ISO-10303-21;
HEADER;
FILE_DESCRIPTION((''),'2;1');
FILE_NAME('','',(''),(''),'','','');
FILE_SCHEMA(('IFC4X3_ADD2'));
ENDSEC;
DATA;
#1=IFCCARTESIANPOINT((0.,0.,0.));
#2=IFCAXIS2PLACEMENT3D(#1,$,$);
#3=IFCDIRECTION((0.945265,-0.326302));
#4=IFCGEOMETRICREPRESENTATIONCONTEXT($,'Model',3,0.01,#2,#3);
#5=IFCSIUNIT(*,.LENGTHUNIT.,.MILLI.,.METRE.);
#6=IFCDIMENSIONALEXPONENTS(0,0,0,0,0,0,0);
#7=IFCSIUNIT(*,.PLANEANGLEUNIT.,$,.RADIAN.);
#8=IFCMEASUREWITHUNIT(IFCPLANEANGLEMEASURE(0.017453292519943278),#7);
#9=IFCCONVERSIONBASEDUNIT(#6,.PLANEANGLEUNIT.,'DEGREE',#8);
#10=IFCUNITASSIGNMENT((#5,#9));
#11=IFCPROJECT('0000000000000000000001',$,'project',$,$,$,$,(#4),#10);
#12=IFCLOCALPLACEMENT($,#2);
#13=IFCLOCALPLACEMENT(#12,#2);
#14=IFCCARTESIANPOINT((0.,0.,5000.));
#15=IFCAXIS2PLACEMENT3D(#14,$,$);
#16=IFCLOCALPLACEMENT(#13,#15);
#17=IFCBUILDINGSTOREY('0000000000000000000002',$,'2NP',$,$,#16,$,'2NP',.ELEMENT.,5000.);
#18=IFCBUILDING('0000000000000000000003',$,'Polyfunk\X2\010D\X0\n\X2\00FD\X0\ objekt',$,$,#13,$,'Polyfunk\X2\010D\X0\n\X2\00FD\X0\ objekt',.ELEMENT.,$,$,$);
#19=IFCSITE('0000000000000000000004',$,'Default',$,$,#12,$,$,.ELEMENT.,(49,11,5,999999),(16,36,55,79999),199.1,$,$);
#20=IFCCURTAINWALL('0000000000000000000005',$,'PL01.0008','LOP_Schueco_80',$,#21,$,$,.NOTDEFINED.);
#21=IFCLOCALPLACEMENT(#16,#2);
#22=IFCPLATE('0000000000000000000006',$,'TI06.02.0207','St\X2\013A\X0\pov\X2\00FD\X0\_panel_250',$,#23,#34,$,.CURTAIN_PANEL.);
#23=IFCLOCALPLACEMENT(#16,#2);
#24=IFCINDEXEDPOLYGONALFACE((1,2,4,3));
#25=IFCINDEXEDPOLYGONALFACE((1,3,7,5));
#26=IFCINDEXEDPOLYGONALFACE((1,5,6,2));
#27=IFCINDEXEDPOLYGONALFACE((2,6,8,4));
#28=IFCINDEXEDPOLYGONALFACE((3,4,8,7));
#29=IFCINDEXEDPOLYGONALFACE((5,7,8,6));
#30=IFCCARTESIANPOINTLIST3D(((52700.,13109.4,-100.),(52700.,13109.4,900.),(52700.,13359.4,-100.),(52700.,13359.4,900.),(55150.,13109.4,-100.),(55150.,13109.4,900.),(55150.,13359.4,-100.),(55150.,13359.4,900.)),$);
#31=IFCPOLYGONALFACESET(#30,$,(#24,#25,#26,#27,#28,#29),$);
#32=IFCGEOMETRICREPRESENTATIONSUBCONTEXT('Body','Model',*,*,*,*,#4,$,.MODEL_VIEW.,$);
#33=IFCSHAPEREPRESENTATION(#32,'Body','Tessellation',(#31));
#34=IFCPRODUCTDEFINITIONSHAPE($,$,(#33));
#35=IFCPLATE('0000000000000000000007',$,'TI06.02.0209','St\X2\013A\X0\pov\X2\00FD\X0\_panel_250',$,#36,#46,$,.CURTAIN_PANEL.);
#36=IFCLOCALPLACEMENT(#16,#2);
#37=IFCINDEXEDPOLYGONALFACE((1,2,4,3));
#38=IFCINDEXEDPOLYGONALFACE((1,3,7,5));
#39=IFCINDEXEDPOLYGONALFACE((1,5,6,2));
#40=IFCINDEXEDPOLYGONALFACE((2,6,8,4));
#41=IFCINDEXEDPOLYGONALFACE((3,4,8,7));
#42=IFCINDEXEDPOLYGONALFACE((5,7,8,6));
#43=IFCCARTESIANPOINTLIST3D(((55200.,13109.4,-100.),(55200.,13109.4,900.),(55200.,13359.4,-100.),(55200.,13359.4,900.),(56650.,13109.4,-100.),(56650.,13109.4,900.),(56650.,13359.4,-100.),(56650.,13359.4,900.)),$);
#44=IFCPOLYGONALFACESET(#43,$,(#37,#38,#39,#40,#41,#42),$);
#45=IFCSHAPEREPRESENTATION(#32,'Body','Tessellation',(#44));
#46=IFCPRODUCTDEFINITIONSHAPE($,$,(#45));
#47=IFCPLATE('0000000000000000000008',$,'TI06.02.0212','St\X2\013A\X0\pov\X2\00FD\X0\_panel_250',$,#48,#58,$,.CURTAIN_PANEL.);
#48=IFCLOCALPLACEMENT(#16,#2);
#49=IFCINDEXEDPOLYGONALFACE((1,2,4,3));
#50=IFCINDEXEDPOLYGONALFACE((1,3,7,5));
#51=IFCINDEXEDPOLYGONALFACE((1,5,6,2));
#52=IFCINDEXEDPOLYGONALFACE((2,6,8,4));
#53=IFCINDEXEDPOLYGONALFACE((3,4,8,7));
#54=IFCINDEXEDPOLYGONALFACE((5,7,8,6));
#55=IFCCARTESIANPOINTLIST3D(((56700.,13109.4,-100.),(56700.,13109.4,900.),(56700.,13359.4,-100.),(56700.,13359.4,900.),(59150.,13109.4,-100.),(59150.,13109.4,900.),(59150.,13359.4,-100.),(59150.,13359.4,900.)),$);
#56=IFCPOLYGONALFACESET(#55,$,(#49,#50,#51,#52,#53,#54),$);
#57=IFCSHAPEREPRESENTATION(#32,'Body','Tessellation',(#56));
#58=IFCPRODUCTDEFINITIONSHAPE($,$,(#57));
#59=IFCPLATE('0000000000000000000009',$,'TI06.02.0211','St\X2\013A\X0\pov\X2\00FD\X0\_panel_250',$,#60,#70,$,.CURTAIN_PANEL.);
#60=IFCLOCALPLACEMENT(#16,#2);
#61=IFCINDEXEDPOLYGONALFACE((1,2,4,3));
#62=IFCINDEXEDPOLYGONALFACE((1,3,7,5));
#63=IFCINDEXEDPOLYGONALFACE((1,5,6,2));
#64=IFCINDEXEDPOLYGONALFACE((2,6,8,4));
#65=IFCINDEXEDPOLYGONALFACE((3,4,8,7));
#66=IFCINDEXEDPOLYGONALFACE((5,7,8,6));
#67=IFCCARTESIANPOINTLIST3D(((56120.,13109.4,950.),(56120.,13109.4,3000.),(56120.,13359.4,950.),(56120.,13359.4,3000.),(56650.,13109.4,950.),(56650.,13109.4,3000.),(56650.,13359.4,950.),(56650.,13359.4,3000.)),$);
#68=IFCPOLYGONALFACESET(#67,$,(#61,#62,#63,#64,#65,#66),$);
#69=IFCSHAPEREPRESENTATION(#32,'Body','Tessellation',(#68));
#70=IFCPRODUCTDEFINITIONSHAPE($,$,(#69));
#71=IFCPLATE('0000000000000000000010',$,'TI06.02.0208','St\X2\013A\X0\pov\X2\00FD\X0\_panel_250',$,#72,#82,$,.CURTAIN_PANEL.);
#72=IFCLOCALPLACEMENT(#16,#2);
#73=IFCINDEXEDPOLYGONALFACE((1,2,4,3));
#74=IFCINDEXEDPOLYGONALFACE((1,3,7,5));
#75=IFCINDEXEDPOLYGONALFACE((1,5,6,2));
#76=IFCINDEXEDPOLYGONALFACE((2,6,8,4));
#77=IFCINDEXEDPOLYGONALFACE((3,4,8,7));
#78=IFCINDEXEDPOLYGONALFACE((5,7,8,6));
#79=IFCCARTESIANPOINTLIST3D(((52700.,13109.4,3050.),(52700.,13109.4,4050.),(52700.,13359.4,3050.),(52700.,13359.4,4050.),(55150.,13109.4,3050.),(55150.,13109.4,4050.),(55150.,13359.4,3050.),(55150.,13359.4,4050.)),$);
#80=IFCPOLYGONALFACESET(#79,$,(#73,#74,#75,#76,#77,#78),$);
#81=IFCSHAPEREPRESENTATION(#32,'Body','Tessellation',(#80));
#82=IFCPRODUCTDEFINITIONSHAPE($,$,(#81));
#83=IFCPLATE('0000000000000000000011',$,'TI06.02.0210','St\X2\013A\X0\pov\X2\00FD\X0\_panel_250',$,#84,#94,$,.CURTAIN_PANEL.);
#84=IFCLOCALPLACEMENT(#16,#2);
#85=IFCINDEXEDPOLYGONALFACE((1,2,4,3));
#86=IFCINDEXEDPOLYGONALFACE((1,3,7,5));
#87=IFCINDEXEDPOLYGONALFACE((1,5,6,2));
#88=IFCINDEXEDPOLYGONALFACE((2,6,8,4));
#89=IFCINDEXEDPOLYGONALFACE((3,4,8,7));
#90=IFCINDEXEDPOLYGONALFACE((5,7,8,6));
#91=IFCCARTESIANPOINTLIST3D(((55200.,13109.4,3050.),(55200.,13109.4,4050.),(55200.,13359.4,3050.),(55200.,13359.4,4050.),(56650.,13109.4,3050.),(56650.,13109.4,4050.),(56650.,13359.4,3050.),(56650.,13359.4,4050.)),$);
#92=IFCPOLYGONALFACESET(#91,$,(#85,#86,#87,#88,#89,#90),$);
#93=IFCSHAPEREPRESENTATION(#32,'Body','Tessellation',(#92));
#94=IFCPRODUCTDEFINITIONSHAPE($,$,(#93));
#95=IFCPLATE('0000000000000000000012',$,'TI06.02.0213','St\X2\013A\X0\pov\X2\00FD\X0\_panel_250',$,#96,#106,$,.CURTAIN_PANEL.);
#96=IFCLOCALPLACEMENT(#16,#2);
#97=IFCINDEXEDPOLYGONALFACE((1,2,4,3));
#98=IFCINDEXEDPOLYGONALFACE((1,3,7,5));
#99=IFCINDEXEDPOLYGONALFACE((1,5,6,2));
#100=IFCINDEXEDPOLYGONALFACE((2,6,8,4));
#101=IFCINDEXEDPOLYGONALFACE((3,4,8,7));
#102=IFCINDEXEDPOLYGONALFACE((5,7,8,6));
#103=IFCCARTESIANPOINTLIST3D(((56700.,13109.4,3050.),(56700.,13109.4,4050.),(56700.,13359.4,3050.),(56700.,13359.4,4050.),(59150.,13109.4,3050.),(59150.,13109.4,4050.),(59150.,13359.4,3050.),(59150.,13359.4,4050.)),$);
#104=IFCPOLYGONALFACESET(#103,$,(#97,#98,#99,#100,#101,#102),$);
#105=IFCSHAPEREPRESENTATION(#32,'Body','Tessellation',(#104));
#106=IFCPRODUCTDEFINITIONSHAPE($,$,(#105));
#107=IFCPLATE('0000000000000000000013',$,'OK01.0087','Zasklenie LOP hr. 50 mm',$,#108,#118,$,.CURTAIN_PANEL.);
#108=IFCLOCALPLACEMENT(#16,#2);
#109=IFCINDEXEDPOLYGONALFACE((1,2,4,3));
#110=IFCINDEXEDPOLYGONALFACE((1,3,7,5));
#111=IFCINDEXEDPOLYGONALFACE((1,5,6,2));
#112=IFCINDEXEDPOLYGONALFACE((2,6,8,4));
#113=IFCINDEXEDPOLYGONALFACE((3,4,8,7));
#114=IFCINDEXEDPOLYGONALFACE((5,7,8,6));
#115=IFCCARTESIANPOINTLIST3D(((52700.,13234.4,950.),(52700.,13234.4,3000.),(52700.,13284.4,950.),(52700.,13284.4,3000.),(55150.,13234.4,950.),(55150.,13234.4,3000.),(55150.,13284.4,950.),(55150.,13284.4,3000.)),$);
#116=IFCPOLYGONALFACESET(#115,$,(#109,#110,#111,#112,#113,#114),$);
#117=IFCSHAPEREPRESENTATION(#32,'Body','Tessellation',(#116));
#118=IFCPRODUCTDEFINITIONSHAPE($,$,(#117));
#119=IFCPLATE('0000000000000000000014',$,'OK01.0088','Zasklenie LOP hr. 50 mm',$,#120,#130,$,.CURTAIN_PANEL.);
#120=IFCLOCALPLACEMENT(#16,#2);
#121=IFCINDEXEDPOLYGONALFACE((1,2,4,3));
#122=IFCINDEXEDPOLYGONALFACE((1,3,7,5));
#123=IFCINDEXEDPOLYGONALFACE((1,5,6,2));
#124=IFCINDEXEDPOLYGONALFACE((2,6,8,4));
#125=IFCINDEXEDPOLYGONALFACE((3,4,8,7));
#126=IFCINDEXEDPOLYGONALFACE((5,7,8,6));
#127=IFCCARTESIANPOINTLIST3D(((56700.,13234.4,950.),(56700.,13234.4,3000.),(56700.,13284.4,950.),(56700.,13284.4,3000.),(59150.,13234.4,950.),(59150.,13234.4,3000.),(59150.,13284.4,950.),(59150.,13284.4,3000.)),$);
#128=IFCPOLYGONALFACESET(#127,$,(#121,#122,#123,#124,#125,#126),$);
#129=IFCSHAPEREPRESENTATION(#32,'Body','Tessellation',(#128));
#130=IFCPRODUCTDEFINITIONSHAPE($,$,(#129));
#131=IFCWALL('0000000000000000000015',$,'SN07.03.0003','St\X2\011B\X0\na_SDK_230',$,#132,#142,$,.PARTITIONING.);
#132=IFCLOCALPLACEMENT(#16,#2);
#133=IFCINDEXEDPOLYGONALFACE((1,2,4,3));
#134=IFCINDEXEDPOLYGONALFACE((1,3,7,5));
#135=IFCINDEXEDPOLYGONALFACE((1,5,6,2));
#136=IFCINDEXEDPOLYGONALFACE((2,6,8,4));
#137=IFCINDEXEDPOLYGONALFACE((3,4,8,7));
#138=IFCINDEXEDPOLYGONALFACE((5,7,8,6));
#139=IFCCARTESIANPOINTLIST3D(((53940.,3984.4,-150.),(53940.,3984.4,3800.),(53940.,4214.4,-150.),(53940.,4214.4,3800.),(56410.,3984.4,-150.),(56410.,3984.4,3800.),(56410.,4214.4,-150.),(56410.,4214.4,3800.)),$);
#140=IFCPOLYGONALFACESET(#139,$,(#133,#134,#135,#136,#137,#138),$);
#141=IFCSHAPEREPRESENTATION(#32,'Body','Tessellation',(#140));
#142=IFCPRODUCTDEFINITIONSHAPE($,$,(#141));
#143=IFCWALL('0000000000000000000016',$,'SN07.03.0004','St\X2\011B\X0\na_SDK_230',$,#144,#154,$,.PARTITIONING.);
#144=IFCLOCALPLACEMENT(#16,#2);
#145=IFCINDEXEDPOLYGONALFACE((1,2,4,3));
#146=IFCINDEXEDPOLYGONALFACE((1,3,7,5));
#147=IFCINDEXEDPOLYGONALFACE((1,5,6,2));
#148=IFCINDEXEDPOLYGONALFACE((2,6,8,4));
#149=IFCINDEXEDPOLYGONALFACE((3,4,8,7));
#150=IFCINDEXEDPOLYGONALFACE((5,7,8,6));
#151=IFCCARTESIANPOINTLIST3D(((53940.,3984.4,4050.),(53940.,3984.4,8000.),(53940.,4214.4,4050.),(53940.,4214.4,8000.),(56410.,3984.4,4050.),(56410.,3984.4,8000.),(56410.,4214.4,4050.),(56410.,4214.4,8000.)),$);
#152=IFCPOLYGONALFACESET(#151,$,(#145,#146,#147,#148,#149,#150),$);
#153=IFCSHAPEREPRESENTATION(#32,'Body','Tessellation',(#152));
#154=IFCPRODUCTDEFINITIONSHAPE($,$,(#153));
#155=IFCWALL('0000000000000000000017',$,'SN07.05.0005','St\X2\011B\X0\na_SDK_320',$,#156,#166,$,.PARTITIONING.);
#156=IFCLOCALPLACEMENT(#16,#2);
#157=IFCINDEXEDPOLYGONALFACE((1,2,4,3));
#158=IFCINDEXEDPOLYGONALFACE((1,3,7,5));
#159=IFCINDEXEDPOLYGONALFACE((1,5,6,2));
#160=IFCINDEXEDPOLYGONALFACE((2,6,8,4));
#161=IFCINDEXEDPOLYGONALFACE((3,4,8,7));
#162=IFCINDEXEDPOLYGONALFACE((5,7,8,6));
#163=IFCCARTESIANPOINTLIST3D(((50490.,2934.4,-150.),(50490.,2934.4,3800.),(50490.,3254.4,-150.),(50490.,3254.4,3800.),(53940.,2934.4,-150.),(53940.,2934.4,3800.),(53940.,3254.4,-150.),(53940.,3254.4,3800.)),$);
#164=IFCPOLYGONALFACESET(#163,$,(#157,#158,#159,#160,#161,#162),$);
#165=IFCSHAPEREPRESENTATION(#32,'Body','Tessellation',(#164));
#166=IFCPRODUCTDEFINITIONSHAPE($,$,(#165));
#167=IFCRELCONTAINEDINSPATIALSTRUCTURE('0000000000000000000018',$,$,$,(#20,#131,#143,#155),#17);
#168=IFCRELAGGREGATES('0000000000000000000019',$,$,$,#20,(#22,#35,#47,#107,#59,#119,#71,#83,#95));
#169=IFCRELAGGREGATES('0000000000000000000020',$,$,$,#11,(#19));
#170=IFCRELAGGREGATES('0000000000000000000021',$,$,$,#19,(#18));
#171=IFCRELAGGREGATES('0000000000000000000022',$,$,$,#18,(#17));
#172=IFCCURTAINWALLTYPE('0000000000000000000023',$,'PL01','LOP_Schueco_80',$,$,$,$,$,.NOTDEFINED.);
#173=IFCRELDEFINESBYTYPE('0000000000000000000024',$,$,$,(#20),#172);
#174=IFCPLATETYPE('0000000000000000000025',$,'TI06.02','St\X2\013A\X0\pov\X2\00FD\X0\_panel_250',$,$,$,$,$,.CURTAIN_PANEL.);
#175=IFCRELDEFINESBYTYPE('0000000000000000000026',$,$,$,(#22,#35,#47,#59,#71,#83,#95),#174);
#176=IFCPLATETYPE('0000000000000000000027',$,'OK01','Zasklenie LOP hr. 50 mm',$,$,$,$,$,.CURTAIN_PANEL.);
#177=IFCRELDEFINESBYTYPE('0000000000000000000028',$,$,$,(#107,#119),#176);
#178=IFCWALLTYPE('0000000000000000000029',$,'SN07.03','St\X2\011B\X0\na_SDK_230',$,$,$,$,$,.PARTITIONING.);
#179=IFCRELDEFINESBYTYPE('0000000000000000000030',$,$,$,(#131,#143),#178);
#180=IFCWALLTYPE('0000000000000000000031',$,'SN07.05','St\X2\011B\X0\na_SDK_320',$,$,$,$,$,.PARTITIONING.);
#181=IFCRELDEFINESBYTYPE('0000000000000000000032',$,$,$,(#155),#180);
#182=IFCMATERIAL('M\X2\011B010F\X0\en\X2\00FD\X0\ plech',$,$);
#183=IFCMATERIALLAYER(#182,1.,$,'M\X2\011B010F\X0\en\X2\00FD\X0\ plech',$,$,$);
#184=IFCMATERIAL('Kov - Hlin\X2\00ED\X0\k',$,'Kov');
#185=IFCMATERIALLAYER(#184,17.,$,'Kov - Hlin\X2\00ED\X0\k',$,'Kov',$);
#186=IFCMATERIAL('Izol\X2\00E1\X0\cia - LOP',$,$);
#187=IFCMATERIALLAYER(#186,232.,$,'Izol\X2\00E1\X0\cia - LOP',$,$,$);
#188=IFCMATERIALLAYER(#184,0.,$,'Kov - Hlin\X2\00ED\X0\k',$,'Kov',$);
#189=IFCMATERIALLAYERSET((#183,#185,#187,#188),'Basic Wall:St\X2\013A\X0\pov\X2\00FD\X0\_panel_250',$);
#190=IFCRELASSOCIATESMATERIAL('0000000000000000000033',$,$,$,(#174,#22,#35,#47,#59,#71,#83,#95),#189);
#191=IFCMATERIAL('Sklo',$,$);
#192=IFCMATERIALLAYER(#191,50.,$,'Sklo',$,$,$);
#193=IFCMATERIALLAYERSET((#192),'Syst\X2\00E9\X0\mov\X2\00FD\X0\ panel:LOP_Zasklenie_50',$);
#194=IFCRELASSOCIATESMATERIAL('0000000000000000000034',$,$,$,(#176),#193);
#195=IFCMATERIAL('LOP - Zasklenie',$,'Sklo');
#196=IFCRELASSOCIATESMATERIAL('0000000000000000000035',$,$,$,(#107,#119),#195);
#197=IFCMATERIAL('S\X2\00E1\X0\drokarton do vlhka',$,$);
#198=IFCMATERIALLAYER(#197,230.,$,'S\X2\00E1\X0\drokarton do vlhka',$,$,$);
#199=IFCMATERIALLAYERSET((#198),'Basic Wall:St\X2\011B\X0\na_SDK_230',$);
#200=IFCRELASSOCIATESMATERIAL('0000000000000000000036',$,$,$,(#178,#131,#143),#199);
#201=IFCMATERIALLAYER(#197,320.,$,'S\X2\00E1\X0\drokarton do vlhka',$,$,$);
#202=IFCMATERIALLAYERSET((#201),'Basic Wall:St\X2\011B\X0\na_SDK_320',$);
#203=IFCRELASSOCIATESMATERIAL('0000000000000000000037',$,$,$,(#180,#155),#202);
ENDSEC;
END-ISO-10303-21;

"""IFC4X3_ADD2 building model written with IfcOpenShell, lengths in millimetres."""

from ifc_helpers import new_model, entity, si_unit, converted_unit, direction, frame, frame_2d, origin, origin_2d_with_axis, place, context, subcontext, project, spatial, polyline, rectangle, extrude, clip, bounded_halfspace, source, transform, mapped, material, layer, layer_set, layer_usage, type_object, type_shapes, element, aggregate, save


model = new_model("IFC4X3_ADD2")

# Units and contexts
model_context = context("Model", 3, precision=0.01, world=origin(), true_north=direction((0.945265, -0.326302)))
body_context = subcontext(model_context, "Body", "Model", "MODEL_VIEW")
ifc_project = project(units=[si_unit("LENGTHUNIT", "METRE", prefix="MILLI"), converted_unit("PLANEANGLEUNIT", "DEGREE", entity("IfcPlaneAngleMeasure", 0.017453292519943278), si_unit("PLANEANGLEUNIT", "RADIAN"), dimensions=[0, 0, 0, 0, 0, 0, 0])], contexts=[model_context])

# Site, building, storey
site_placement = place(None, origin())
site = spatial("IfcSite", under=ifc_project, at=site_placement, Name="Default", CompositionType="ELEMENT", RefLatitude=(49, 11, 5, 999999), RefLongitude=(16, 36, 55, 79999), RefElevation=199.1)
building_placement = place(site_placement, origin())
building = spatial("IfcBuilding", under=site, at=building_placement, Name="Polyfunkčný objekt", LongName="Polyfunkčný objekt", CompositionType="ELEMENT")
storey_placement = place(building_placement, frame((0.0, 0.0, 5000.0)))
storey = spatial("IfcBuildingStorey", under=building, at=storey_placement, Name="2NP", LongName="2NP", CompositionType="ELEMENT", Elevation=5000.0)

# Curtain wall, plates
curtain_wall_type = type_object("IfcCurtainWallType", Name="PL01", Description="LOP_Schueco_80", PredefinedType="NOTDEFINED")
curtain_wall_placement = place(storey_placement, frame((0.0, 0.0, -5000.0)))
curtain_wall = element("IfcCurtainWall", 1, at=curtain_wall_placement, inside=storey, type_object=curtain_wall_type, Name="PL01.0008", Description="LOP_Schueco_80", PredefinedType="NOTDEFINED")
ifc_material_1 = material(Name="Měďený plech")
ifc_layer_1 = layer(ifc_material_1, 1.0, Name="Měďený plech")
ifc_material_2 = material(Name="Kov - Hliník", Category="Kov")
ifc_layer_2 = layer(ifc_material_2, 17.0, Name="Kov - Hliník", Category="Kov")
ifc_material_3 = material(Name="Izolácia - LOP")
ifc_layer_3 = layer(ifc_material_3, 232.0, Name="Izolácia - LOP")
ifc_layer_4 = layer(ifc_material_2, 0.0, Name="Kov - Hliník", Category="Kov")
ifc_layer_set_1 = layer_set([ifc_layer_1, ifc_layer_2, ifc_layer_3, ifc_layer_4], Name="Basic Wall:Stĺpový_panel_250")
ifc_layer_usage_1 = layer_usage(ifc_layer_set_1, "AXIS2", "NEGATIVE", 125.0)
plate_type_1 = type_object("IfcPlateType", Name="TI06.02", Description="Stĺpový_panel_250", PredefinedType="CURTAIN_PANEL", material=ifc_layer_set_1)
plate_1_placement = place(storey_placement, frame((52700.0, 13234.4, -100.0)))
plate_1 = element("IfcPlate", 2, at=plate_1_placement, type_object=plate_type_1, material=ifc_layer_usage_1, Name="TI06.02.0207", Description="Stĺpový_panel_250", PredefinedType="CURTAIN_PANEL", context=body_context, shape_type="SweptSolid", body=[
    extrude(rectangle(XDim=250.0, YDim=2450.0, at=origin_2d_with_axis()), frame((1225.0, 0.0, 0.0), z_axis=(0.0, 0.0, 1.0), x_axis=(0.0, 1.0, 0.0)), (0.0, 0.0, 1.0), 1000.0),
])
ifc_layer_usage_2 = layer_usage(ifc_layer_set_1, "AXIS2", "NEGATIVE", 125.0)
plate_2_placement = place(storey_placement, frame((55200.0, 13234.4, -100.0)))
plate_2 = element("IfcPlate", 3, at=plate_2_placement, type_object=plate_type_1, material=ifc_layer_usage_2, Name="TI06.02.0209", Description="Stĺpový_panel_250", PredefinedType="CURTAIN_PANEL", context=body_context, shape_type="SweptSolid", body=[
    extrude(rectangle(XDim=250.0, YDim=1450.0, at=origin_2d_with_axis()), frame((725.0, 0.0, 0.0), z_axis=(0.0, 0.0, 1.0), x_axis=(0.0, 1.0, 0.0)), (0.0, 0.0, 1.0), 1000.0),
])
ifc_layer_usage_3 = layer_usage(ifc_layer_set_1, "AXIS2", "NEGATIVE", 125.0)
plate_3_placement = place(storey_placement, frame((56700.0, 13234.4, -100.0)))
plate_3 = element("IfcPlate", 4, at=plate_3_placement, type_object=plate_type_1, material=ifc_layer_usage_3, Name="TI06.02.0212", Description="Stĺpový_panel_250", PredefinedType="CURTAIN_PANEL", context=body_context, shape_type="SweptSolid", body=[
    extrude(rectangle(XDim=250.0, YDim=2450.0, at=frame_2d((0.0, 0.0), x_axis=(1.0, 0.0))), frame((1225.0, 0.0, 0.0), z_axis=(0.0, 0.0, 1.0), x_axis=(0.0, 1.0, 0.0)), (0.0, 0.0, 1.0), 1000.0),
])
ifc_layer_usage_4 = layer_usage(ifc_layer_set_1, "AXIS2", "NEGATIVE", 125.0)
plate_4_placement = place(storey_placement, frame((56120.0, 13234.4, 950.0)))
plate_4 = element("IfcPlate", 5, at=plate_4_placement, type_object=plate_type_1, material=ifc_layer_usage_4, Name="TI06.02.0211", Description="Stĺpový_panel_250", PredefinedType="CURTAIN_PANEL", context=body_context, shape_type="SweptSolid", body=[
    extrude(rectangle(XDim=250.0, YDim=530.0, at=frame_2d((0.0, 0.0), x_axis=(1.0, 0.0))), frame((265.0, 0.0, 0.0), z_axis=(0.0, 0.0, 1.0), x_axis=(0.0, 1.0, 0.0)), (0.0, 0.0, 1.0), 2050.0),
])
ifc_layer_usage_5 = layer_usage(ifc_layer_set_1, "AXIS2", "NEGATIVE", 125.0)
plate_5_placement = place(storey_placement, frame((52700.0, 13234.4, 3050.0)))
plate_5 = element("IfcPlate", 6, at=plate_5_placement, type_object=plate_type_1, material=ifc_layer_usage_5, Name="TI06.02.0208", Description="Stĺpový_panel_250", PredefinedType="CURTAIN_PANEL", context=body_context, shape_type="SweptSolid", body=[
    extrude(rectangle(XDim=250.0, YDim=2450.0, at=origin_2d_with_axis()), frame((1225.0, 0.0, 0.0), z_axis=(0.0, 0.0, 1.0), x_axis=(0.0, 1.0, 0.0)), (0.0, 0.0, 1.0), 1000.0),
])
ifc_layer_usage_6 = layer_usage(ifc_layer_set_1, "AXIS2", "NEGATIVE", 125.0)
plate_6_placement = place(storey_placement, frame((55200.0, 13234.4, 3050.0)))
plate_6 = element("IfcPlate", 7, at=plate_6_placement, type_object=plate_type_1, material=ifc_layer_usage_6, Name="TI06.02.0210", Description="Stĺpový_panel_250", PredefinedType="CURTAIN_PANEL", context=body_context, shape_type="SweptSolid", body=[
    extrude(rectangle(XDim=250.0, YDim=1450.0, at=origin_2d_with_axis()), frame((725.0, 0.0, 0.0), z_axis=(0.0, 0.0, 1.0), x_axis=(0.0, 1.0, 0.0)), (0.0, 0.0, 1.0), 1000.0),
])
ifc_layer_usage_7 = layer_usage(ifc_layer_set_1, "AXIS2", "NEGATIVE", 125.0)
plate_7_placement = place(storey_placement, frame((56700.0, 13234.4, 3050.0)))
plate_7 = element("IfcPlate", 8, at=plate_7_placement, type_object=plate_type_1, material=ifc_layer_usage_7, Name="TI06.02.0213", Description="Stĺpový_panel_250", PredefinedType="CURTAIN_PANEL", context=body_context, shape_type="SweptSolid", body=[
    extrude(rectangle(XDim=250.0, YDim=2450.0, at=frame_2d((0.0, 0.0), x_axis=(1.0, 0.0))), frame((1225.0, 0.0, 0.0), z_axis=(0.0, 0.0, 1.0), x_axis=(0.0, 1.0, 0.0)), (0.0, 0.0, 1.0), 1000.0),
])
ifc_material_4 = material(Name="LOP - Zasklenie", Category="Sklo")
ifc_material_5 = material(Name="Sklo")
ifc_layer_5 = layer(ifc_material_5, 50.0, Name="Sklo")
ifc_layer_set_2 = layer_set([ifc_layer_5], Name="Systémový panel:LOP_Zasklenie_50")
plate_type_2 = type_object("IfcPlateType", Name="OK01", Description="Zasklenie LOP hr. 50 mm", PredefinedType="CURTAIN_PANEL", material=ifc_layer_set_2)
shared_shape_1 = source(origin(), body_context, "Body", "SweptSolid", [
    extrude(rectangle(XDim=50.0, YDim=2450.0, at=origin_2d_with_axis()), frame((0.0, 25.0, 0.0), z_axis=(0.0, 0.0, 1.0), x_axis=(0.0, 1.0, 0.0)), (0.0, 0.0, 1.0), 2050.0),
])
type_shapes(plate_type_2, [shared_shape_1])
plate_8_placement = place(curtain_wall_placement, frame((53925.0, 13234.4, 5950.0)))
plate_8 = element("IfcPlate", 9, at=plate_8_placement, type_object=plate_type_2, material=ifc_material_4, Name="OK01.0087", Description="Zasklenie LOP hr. 50 mm", PredefinedType="CURTAIN_PANEL", context=body_context, shape_type="MappedRepresentation", body=[
    mapped(shared_shape_1, transform((0.0, 0.0, 0.0), scale=1.0)),
])
plate_9_placement = place(curtain_wall_placement, frame((57925.0, 13234.4, 5950.0)))
plate_9 = element("IfcPlate", 10, at=plate_9_placement, type_object=plate_type_2, material=ifc_material_4, Name="OK01.0088", Description="Zasklenie LOP hr. 50 mm", PredefinedType="CURTAIN_PANEL", context=body_context, shape_type="MappedRepresentation", body=[
    mapped(shared_shape_1, transform((0.0, 0.0, 0.0), scale=1.0)),
])

# Walls
ifc_material_6 = material(Name="Sádrokarton do vlhka")
ifc_layer_6 = layer(ifc_material_6, 230.0, Name="Sádrokarton do vlhka")
ifc_layer_set_3 = layer_set([ifc_layer_6], Name="Basic Wall:Stěna_SDK_230")
wall_type_1 = type_object("IfcWallType", Name="SN07.03", Description="Stěna_SDK_230", PredefinedType="PARTITIONING", material=ifc_layer_set_3)
wall_1_placement = place(storey_placement, frame((56410.0, 4099.4, -150.0), z_axis=(0.0, 0.0, 1.0), x_axis=(-1.0, 0.0, 0.0)))
element("IfcWall", 11, at=wall_1_placement, inside=storey, type_object=wall_type_1, material=ifc_layer_set_3, Name="SN07.03.0003", Description="Stěna_SDK_230", PredefinedType="PARTITIONING", context=body_context, shape_type="Clipping", body=[
    clip(clip(extrude(rectangle(XDim=2470.0, YDim=230.0, at=frame_2d((1235.0, 0.0), x_axis=(-1.0, 0.0))), origin(), (0.0, 0.0, 1.0), 3950.0), bounded_halfspace(frame((2470.0, -115.0, 0.0)), True, frame((2470.0, -115.0, 0.0)), polyline([(0.0, 0.0), (0.0, 60.0), (0.0, 230.0), (-320.0, 230.0), (-2470.0, 230.0), (-2470.0, 0.0), (-150.0, 0.0), (0.0, 0.0)]))), bounded_halfspace(frame((0.0, -115.0, 3950.0), z_axis=(0.0, 0.0, -1.0), x_axis=(-1.0, 0.0, 0.0)), True, frame((0.0, -115.0, 3950.0)), polyline([(0.0, 0.0), (2320.0, 0.0), (2470.0, 0.0), (2470.0, 60.0), (2470.0, 230.0), (2150.0, 230.0), (0.0, 230.0), (0.0, 0.0)]))),
])
wall_2_placement = place(storey_placement, frame((56410.0, 4099.4, 4050.0), z_axis=(0.0, 0.0, 1.0), x_axis=(-1.0, 0.0, 0.0)))
element("IfcWall", 12, at=wall_2_placement, inside=storey, type_object=wall_type_1, material=ifc_layer_set_3, Name="SN07.03.0004", Description="Stěna_SDK_230", PredefinedType="PARTITIONING", context=body_context, shape_type="Clipping", body=[
    clip(clip(extrude(rectangle(XDim=2470.0, YDim=230.0, at=frame_2d((1235.0, 0.0), x_axis=(-1.0, 0.0))), origin(), (0.0, 0.0, 1.0), 3950.0), bounded_halfspace(frame((2470.0, -115.0, 0.0)), True, frame((2470.0, -115.0, 0.0)), polyline([(0.0, 0.0), (0.0, 60.0), (0.0, 230.0), (-320.0, 230.0), (-2470.0, 230.0), (-2470.0, 0.0), (-150.0, 0.0), (0.0, 0.0)]))), bounded_halfspace(frame((0.0, -115.0, 3950.0), z_axis=(0.0, 0.0, -1.0), x_axis=(-1.0, 0.0, 0.0)), True, frame((0.0, -115.0, 3950.0)), polyline([(0.0, 0.0), (2320.0, 0.0), (2470.0, 0.0), (2470.0, 60.0), (2470.0, 230.0), (2150.0, 230.0), (0.0, 230.0), (0.0, 0.0)]))),
])
ifc_layer_7 = layer(ifc_material_6, 320.0, Name="Sádrokarton do vlhka")
ifc_layer_set_4 = layer_set([ifc_layer_7], Name="Basic Wall:Stěna_SDK_320")
wall_type_2 = type_object("IfcWallType", Name="SN07.05", Description="Stěna_SDK_320", PredefinedType="PARTITIONING", material=ifc_layer_set_4)
wall_3_placement = place(storey_placement, frame((53940.0, 3094.4, -150.0), z_axis=(0.0, 0.0, 1.0), x_axis=(-1.0, 0.0, 0.0)))
element("IfcWall", 13, at=wall_3_placement, inside=storey, type_object=wall_type_2, material=ifc_layer_set_4, Name="SN07.05.0005", Description="Stěna_SDK_320", PredefinedType="PARTITIONING", context=body_context, shape_type="Clipping", body=[
    clip(clip(extrude(rectangle(XDim=3450.0, YDim=320.0, at=frame_2d((1725.0, 0.0), x_axis=(-1.0, 0.0))), origin(), (0.0, 0.0, 1.0), 3950.0), bounded_halfspace(frame((3450.0, -160.0, 0.0)), True, frame((3450.0, -160.0, 0.0)), polyline([(0.0, 0.0), (0.0, 320.0), (-1650.0, 320.0), (-1800.0, 320.0), (-3450.0, 320.0), (-3450.0, 0.0), (-1800.0, 0.0), (-1650.0, 0.0), (0.0, 0.0)]))), bounded_halfspace(frame((0.0, -160.0, 3950.0), z_axis=(0.0, 0.0, -1.0), x_axis=(-1.0, 0.0, 0.0)), True, frame((0.0, -160.0, 3950.0)), polyline([(0.0, 0.0), (1650.0, 0.0), (1800.0, 0.0), (3450.0, 0.0), (3450.0, 320.0), (1800.0, 320.0), (1650.0, 320.0), (0.0, 320.0), (0.0, 0.0)]))),
])

aggregate(curtain_wall, [plate_1, plate_2, plate_3, plate_8, plate_4, plate_9, plate_5, plate_6, plate_7])

save(model, "model.ifc")
